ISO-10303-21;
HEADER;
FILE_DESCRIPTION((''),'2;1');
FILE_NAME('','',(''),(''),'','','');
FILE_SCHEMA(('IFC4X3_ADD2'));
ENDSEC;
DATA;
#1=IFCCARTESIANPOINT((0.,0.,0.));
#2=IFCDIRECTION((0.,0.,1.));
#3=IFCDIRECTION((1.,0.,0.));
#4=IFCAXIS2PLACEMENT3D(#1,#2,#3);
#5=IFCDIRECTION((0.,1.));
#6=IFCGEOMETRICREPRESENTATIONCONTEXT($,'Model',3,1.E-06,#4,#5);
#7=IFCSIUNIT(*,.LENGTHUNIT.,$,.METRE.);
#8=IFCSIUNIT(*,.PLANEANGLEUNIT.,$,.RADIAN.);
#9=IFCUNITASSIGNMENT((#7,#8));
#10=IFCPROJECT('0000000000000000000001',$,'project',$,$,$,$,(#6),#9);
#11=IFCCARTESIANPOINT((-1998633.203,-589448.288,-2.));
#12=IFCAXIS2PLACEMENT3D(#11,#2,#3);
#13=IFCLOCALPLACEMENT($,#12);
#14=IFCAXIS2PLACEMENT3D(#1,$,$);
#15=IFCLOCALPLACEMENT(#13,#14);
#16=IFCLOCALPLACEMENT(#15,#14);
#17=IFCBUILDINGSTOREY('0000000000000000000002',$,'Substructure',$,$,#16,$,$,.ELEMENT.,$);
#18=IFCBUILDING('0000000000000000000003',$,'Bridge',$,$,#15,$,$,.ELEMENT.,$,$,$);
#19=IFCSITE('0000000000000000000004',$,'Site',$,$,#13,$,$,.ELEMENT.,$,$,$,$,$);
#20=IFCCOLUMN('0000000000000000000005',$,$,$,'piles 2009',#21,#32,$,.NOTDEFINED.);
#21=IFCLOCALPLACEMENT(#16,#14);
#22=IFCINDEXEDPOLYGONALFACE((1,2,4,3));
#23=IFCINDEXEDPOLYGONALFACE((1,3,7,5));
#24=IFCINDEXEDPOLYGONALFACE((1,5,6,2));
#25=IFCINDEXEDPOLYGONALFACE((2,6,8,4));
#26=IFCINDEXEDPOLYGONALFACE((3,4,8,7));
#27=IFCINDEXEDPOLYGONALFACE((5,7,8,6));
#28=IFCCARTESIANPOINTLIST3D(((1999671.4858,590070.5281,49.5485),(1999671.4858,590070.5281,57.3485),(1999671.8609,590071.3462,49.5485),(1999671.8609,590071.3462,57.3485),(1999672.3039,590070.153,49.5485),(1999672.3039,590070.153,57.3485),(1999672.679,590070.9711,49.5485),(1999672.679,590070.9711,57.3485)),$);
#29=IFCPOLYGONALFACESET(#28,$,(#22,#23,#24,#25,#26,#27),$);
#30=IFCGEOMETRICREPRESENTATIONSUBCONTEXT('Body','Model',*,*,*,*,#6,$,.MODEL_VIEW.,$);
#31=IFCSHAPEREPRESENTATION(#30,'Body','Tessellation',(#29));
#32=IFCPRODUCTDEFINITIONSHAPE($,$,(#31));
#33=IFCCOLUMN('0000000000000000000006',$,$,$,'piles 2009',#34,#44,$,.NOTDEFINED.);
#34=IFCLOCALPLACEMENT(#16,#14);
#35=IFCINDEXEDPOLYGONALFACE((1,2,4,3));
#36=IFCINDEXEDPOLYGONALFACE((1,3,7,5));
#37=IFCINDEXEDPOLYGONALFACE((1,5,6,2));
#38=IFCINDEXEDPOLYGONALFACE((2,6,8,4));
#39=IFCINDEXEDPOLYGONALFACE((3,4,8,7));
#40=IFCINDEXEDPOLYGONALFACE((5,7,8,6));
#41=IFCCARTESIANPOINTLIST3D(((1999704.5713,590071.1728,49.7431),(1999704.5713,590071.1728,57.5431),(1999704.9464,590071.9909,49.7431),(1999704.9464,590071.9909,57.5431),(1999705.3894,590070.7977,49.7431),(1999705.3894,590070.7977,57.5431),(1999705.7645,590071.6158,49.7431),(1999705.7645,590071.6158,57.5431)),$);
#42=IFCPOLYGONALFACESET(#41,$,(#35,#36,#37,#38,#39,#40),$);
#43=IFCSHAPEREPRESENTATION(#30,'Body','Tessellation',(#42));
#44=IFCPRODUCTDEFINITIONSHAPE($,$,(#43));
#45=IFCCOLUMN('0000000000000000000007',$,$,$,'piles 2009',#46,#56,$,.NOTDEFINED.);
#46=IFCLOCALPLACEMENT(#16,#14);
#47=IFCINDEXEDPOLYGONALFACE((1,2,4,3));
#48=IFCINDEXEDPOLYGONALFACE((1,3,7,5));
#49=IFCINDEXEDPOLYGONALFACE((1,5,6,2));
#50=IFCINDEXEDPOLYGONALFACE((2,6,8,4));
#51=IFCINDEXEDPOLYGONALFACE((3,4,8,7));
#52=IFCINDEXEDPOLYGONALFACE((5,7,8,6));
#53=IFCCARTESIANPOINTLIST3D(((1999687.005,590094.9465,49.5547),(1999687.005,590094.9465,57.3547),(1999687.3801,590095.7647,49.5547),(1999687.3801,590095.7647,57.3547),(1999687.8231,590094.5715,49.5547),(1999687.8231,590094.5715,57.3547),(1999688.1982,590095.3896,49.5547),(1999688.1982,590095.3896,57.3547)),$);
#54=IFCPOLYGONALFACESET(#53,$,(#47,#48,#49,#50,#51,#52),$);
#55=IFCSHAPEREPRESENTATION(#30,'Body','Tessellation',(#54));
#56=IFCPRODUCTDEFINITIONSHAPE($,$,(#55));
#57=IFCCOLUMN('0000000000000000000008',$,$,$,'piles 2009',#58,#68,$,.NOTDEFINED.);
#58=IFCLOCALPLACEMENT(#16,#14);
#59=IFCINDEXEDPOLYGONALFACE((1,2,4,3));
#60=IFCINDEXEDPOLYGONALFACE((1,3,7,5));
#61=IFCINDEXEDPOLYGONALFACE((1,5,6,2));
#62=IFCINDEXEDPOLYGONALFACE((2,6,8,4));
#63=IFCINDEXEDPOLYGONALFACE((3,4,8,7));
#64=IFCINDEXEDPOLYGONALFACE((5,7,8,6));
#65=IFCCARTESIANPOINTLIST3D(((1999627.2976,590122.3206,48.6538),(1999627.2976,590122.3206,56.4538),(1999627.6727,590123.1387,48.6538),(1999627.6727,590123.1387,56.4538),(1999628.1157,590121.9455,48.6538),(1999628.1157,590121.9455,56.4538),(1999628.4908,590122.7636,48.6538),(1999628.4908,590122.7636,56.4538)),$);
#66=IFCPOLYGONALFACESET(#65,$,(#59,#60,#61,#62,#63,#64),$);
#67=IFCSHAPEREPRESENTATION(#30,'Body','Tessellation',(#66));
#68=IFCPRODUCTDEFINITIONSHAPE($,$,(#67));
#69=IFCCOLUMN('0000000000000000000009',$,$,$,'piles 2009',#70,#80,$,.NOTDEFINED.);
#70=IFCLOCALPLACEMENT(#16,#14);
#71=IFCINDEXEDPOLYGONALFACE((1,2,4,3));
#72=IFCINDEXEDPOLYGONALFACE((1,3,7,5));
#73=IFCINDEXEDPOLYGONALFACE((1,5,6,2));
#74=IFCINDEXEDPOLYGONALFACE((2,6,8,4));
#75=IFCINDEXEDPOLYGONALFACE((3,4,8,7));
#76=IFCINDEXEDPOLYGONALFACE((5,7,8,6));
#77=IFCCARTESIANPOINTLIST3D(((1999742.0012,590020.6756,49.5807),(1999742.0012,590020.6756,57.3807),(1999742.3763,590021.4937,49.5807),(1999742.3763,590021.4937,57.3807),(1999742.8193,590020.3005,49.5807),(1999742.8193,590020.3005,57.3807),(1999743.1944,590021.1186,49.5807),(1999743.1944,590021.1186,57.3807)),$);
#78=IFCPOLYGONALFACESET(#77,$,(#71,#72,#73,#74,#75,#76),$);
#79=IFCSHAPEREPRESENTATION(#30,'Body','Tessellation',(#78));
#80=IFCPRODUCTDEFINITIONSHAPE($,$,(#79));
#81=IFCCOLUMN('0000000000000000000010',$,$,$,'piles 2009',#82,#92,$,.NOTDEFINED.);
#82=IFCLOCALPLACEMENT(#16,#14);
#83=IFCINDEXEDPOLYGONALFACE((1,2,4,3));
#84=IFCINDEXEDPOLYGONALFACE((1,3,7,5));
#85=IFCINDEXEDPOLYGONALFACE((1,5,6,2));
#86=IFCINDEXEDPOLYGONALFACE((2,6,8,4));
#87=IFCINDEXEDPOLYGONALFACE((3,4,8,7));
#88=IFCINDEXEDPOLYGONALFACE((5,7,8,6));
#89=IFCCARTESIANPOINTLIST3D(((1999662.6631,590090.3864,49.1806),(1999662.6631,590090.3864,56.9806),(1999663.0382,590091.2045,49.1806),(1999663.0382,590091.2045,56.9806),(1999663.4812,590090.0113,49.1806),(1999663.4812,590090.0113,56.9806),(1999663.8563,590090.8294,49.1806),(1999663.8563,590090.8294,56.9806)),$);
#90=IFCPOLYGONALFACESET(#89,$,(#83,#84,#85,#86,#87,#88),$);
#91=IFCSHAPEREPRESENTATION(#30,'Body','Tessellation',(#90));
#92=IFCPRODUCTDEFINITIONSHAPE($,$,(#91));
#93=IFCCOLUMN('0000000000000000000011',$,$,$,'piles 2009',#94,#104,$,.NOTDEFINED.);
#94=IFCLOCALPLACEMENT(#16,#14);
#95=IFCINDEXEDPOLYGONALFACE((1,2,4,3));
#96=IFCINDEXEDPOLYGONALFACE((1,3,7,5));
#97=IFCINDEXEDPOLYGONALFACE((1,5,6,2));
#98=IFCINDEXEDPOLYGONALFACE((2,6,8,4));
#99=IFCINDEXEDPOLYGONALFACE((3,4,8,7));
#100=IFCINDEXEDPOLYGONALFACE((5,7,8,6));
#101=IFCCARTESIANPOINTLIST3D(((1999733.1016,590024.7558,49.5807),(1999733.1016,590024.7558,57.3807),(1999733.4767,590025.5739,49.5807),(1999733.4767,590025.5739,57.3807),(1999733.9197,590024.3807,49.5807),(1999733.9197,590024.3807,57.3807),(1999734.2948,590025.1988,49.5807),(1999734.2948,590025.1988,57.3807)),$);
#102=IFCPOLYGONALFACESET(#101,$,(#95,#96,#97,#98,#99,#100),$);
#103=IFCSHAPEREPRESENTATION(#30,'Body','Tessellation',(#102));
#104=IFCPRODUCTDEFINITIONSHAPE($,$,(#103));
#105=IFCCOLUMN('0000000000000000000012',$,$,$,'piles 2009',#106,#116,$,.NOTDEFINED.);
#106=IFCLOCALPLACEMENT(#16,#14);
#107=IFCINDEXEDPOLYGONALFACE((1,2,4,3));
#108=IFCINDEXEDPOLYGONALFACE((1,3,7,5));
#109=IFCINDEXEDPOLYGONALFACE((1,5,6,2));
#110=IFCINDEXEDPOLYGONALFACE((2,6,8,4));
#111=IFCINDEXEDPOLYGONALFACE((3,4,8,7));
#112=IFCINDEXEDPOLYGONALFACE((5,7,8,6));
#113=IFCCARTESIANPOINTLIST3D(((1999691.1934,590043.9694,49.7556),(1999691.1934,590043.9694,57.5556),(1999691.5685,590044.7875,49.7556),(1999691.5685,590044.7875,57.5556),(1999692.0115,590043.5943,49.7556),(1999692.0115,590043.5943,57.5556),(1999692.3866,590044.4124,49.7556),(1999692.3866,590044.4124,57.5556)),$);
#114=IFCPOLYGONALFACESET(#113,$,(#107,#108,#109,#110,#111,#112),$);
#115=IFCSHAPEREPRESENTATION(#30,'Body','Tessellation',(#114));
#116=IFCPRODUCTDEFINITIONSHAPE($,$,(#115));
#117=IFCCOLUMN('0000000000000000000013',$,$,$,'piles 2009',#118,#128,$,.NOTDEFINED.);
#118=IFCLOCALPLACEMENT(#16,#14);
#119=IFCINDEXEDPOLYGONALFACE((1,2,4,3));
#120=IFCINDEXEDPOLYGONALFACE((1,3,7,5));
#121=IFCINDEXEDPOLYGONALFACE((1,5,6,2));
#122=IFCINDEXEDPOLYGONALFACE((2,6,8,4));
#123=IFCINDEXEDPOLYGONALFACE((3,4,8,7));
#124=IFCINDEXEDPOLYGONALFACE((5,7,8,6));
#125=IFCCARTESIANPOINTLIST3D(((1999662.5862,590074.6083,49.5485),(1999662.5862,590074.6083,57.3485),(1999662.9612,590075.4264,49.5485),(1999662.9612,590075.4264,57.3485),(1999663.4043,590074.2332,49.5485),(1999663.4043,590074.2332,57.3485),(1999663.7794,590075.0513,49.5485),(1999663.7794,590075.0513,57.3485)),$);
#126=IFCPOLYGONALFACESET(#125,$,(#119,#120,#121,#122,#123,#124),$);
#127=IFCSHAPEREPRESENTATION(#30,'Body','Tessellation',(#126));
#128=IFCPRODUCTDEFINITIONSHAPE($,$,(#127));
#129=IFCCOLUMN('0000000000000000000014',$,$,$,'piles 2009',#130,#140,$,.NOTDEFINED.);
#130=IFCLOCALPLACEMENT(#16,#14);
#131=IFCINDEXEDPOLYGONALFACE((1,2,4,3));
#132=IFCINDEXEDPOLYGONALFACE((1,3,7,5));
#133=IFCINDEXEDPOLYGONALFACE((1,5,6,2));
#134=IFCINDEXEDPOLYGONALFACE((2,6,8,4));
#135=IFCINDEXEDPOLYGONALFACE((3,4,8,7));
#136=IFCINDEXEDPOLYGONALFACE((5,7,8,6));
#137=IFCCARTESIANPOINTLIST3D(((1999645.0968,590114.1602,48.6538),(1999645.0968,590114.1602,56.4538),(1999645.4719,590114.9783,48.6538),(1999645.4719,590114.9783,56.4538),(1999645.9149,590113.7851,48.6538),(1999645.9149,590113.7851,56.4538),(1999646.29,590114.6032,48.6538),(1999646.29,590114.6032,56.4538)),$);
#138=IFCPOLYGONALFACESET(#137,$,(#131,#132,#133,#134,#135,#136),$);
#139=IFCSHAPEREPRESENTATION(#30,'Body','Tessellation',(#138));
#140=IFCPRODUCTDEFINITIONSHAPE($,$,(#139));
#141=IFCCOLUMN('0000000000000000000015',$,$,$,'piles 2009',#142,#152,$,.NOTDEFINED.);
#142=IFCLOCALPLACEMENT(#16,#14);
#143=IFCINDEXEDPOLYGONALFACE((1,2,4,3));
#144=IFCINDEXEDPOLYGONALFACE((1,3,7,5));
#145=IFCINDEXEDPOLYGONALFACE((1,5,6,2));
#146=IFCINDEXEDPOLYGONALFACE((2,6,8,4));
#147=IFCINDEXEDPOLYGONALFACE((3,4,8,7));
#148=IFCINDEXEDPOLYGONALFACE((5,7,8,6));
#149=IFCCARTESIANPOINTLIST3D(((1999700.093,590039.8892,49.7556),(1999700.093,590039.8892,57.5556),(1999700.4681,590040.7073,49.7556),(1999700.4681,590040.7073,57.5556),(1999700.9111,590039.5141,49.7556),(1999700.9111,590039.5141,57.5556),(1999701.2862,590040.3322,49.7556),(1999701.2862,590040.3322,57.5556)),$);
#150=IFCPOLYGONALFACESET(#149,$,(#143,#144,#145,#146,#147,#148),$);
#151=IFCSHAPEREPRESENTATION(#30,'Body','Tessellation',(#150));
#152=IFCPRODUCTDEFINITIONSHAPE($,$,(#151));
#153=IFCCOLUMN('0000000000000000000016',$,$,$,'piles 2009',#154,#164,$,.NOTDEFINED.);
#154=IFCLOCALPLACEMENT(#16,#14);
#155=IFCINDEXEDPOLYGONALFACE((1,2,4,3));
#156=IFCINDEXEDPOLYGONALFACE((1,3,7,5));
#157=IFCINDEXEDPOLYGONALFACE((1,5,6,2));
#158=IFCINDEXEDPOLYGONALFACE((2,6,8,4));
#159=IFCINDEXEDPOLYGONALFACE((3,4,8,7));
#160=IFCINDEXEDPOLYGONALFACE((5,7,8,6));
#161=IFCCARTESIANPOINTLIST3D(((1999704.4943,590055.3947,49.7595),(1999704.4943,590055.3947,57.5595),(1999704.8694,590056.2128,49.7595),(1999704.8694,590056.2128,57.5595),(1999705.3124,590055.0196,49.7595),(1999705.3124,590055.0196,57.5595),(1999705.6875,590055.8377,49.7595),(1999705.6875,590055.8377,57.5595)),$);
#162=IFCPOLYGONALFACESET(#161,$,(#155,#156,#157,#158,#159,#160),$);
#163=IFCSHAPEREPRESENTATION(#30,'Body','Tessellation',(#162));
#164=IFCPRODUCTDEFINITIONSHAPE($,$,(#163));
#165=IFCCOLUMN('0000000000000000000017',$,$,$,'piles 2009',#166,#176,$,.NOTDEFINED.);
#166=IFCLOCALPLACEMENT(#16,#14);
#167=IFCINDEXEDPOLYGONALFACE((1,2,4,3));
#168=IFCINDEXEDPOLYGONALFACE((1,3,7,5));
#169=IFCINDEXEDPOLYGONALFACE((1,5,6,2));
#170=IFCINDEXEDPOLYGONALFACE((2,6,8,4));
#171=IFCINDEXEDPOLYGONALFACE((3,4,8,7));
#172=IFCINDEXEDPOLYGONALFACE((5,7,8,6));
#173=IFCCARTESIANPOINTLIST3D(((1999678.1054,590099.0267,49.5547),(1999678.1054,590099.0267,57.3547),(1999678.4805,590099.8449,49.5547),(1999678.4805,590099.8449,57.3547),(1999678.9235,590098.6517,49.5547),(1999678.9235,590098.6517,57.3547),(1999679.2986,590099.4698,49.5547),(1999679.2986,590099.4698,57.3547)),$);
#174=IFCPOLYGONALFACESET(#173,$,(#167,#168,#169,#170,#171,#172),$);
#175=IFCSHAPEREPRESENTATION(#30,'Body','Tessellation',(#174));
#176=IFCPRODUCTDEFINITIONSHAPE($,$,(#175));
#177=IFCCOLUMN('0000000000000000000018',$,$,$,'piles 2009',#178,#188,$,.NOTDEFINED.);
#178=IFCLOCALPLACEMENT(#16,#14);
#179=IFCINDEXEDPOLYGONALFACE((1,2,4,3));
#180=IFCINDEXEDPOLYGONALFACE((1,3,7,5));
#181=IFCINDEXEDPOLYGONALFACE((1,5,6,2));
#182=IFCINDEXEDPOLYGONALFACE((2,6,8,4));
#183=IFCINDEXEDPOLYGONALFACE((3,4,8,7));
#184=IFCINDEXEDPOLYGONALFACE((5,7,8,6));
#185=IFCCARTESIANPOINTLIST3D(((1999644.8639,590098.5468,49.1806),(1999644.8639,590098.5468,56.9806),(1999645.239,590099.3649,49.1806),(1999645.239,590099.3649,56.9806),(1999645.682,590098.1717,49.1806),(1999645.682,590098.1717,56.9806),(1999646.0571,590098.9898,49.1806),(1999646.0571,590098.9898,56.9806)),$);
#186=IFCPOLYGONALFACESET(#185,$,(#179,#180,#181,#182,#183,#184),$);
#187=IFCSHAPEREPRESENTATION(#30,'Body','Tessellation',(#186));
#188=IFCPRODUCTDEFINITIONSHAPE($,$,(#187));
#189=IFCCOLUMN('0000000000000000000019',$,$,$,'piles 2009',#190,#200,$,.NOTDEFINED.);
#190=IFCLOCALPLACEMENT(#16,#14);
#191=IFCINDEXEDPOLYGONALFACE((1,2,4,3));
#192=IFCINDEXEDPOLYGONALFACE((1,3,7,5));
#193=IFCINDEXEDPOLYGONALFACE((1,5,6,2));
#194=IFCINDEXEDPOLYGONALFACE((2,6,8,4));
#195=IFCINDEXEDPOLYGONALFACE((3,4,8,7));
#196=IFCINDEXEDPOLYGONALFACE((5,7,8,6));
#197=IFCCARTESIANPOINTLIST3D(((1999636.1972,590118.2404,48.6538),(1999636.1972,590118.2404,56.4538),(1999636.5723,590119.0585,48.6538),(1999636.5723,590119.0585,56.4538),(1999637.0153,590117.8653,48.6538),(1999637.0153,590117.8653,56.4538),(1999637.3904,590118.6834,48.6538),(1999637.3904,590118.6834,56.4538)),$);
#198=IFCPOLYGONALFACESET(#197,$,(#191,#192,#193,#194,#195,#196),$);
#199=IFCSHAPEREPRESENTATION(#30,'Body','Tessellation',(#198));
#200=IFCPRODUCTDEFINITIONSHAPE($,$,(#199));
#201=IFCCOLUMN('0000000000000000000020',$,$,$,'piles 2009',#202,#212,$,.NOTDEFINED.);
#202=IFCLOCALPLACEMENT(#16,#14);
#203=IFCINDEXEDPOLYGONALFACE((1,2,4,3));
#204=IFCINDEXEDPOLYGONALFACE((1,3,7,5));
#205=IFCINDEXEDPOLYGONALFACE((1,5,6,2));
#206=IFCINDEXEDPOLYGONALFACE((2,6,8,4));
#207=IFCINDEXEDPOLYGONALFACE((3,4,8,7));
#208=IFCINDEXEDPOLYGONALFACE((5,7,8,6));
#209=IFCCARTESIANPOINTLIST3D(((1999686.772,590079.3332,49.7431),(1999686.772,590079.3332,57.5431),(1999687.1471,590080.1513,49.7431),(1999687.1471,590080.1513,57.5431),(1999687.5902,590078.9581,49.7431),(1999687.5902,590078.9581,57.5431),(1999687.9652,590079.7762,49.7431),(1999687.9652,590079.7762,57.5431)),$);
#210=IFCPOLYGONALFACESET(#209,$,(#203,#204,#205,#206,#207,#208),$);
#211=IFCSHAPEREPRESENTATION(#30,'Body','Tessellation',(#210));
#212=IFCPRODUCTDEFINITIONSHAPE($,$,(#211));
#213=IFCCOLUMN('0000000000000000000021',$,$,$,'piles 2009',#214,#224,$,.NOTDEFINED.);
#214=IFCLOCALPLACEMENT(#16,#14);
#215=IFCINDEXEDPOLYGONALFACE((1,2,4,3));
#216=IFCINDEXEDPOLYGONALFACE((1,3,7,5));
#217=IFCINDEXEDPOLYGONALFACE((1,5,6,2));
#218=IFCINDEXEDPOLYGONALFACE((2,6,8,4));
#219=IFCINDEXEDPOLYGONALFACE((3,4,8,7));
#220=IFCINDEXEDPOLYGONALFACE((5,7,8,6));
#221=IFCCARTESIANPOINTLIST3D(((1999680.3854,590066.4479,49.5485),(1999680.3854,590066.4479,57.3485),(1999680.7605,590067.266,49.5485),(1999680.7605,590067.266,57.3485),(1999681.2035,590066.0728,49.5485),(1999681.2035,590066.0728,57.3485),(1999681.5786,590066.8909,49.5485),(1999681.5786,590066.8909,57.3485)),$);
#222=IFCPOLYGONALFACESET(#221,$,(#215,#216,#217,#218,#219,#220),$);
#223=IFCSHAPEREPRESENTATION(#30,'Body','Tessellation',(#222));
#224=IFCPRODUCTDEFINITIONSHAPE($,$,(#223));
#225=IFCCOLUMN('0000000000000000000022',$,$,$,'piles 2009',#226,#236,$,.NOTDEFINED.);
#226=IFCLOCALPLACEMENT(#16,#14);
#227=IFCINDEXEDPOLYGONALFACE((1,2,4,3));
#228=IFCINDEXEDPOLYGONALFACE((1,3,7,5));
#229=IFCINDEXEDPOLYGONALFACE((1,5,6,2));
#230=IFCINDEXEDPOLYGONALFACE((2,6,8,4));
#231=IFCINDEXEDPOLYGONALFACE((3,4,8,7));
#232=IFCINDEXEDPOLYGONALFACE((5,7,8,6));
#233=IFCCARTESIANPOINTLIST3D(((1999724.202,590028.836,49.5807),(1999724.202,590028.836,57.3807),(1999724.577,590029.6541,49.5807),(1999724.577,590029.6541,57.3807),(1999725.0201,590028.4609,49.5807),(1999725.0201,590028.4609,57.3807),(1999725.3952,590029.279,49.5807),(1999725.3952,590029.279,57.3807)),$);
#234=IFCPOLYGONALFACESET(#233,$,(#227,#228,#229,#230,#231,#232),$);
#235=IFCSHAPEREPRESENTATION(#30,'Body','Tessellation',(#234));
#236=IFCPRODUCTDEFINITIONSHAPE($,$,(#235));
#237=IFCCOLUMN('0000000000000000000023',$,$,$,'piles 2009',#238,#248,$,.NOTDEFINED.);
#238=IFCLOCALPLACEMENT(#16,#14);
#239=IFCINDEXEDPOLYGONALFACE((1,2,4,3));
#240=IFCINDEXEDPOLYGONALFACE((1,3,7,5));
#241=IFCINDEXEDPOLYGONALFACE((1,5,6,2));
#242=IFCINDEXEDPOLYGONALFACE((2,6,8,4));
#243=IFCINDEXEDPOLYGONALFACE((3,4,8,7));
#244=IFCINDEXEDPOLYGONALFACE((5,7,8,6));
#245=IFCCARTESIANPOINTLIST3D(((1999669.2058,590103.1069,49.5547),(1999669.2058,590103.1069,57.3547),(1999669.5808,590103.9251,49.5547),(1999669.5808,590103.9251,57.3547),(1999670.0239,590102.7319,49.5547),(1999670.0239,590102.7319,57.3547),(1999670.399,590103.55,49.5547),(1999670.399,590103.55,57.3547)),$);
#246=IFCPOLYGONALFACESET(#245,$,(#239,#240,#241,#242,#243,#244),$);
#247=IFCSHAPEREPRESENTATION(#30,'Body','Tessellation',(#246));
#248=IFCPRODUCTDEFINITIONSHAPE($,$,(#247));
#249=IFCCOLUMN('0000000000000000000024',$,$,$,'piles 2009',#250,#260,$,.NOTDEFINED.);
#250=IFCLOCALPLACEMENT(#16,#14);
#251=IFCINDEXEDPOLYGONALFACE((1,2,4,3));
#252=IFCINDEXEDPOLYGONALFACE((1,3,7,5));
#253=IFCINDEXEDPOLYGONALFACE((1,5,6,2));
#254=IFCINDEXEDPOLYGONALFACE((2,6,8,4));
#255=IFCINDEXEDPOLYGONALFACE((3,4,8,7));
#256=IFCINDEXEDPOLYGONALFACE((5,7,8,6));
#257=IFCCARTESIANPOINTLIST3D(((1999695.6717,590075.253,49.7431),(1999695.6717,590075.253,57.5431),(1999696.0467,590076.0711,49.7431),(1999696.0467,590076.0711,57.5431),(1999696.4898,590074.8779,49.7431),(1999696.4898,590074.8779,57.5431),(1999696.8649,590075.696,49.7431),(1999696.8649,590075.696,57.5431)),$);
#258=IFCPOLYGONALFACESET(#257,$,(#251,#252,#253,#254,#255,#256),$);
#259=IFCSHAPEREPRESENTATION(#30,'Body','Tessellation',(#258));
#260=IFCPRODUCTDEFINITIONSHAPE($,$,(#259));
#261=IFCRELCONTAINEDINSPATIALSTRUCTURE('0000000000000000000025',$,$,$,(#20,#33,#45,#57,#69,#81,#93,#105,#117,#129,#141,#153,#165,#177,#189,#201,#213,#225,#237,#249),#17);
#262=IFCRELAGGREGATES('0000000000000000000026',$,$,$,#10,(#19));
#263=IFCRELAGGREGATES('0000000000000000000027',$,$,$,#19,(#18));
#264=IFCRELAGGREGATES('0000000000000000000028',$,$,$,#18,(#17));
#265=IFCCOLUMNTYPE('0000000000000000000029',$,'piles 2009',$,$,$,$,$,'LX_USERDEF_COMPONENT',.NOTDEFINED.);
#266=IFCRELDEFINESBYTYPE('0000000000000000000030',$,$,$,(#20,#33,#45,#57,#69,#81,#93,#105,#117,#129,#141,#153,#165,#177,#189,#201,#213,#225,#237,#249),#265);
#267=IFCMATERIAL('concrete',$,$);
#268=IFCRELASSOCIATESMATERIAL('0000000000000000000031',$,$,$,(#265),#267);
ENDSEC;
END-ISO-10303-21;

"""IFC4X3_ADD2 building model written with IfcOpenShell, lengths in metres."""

from ifc_helpers import new_model, si_unit, direction, frame, frame_2d, origin, origin_with_axes, place, context, subcontext, project, spatial, rectangle, extrude, material, type_object, element, save


model = new_model("IFC4X3_ADD2")

# Units and contexts
model_context = context("Model", 3, precision=1e-06, world=origin_with_axes(), true_north=direction((0.0, 1.0)))
body_context = subcontext(model_context, "Body", "Model", "MODEL_VIEW")
ifc_project = project(units=[si_unit("LENGTHUNIT", "METRE"), si_unit("PLANEANGLEUNIT", "RADIAN")], contexts=[model_context])

# Site, building, storey
site_placement = place(None, frame((-1998633.203, -589448.288, -2.0), z_axis=(0.0, 0.0, 1.0), x_axis=(1.0, 0.0, 0.0)))
site = spatial("IfcSite", under=ifc_project, at=site_placement, Name="Site", CompositionType="ELEMENT")
building_placement = place(site_placement, origin())
building = spatial("IfcBuilding", under=site, at=building_placement, Name="Bridge", CompositionType="ELEMENT")
storey_placement = place(building_placement, origin())
storey = spatial("IfcBuildingStorey", under=building, at=storey_placement, Name="Substructure", CompositionType="ELEMENT")

# Columns
ifc_material = material(Name="concrete")
column_type = type_object("IfcColumnType", Name="piles 2009", ElementType="LX_USERDEF_COMPONENT", PredefinedType="NOTDEFINED", material=ifc_material)
for number, where, z_axis, x_axis in (
    (1, (1999672.3039, 590070.153, 49.5485), (0.0, 0.0, 1.0), (0.416757, 0.909018, 0.0)),
    (2, (1999705.3894, 590070.7977, 49.7431), (0.0, 0.0, 1.0), (0.416757, 0.909018, 0.0)),
    (3, (1999687.8231, 590094.5715, 49.5547), (0.0, 0.0, 1.0), (0.416757, 0.909018, 0.0)),
    (4, (1999628.1157, 590121.9455, 48.6538), (0.0, 0.0, 1.0), (0.416757, 0.909018, 0.0)),
    (5, (1999742.8193, 590020.3005, 49.5807), (0.0, 0.0, 1.0), (0.416757, 0.909018, 0.0)),
    (6, (1999663.4812, 590090.0113, 49.1806), (0.0, 0.0, 1.0), (0.416757, 0.909018, 0.0)),
    (7, (1999733.9197, 590024.3807, 49.5807), (0.0, 0.0, 1.0), (0.416757, 0.909018, 0.0)),
    (8, (1999692.0115, 590043.5943, 49.7556), (0.0, 0.0, 1.0), (0.416757, 0.909018, 0.0)),
    (9, (1999663.4043, 590074.2332, 49.5485), (0.0, 0.0, 1.0), (0.416757, 0.909018, 0.0)),
    (10, (1999645.9149, 590113.7851, 48.6538), (0.0, 0.0, 1.0), (0.416757, 0.909018, 0.0)),
    (11, (1999700.9111, 590039.5141, 49.7556), (0.0, 0.0, 1.0), (0.416757, 0.909018, 0.0)),
    (12, (1999705.3124, 590055.0196, 49.7595), (0.0, 0.0, 1.0), (0.416757, 0.909018, 0.0)),
    (13, (1999678.9235, 590098.6517, 49.5547), (0.0, 0.0, 1.0), (0.416757, 0.909018, 0.0)),
    (14, (1999645.682, 590098.1717, 49.1806), (0.0, 0.0, 1.0), (0.416757, 0.909018, 0.0)),
    (15, (1999637.0153, 590117.8653, 48.6538), (0.0, 0.0, 1.0), (0.416757, 0.909018, 0.0)),
    (16, (1999687.5902, 590078.9581, 49.7431), (0.0, 0.0, 1.0), (0.416757, 0.909018, 0.0)),
    (17, (1999681.2035, 590066.0728, 49.5485), (0.0, 0.0, 1.0), (0.416757, 0.909018, 0.0)),
    (18, (1999725.0201, 590028.4609, 49.5807), (0.0, 0.0, 1.0), (0.416757, 0.909018, 0.0)),
    (19, (1999670.0239, 590102.7319, 49.5547), (0.0, 0.0, 1.0), (0.416757, 0.909018, 0.0)),
    (20, (1999696.4898, 590074.8779, 49.7431), (0.0, 0.0, 1.0), (0.416757, 0.909018, 0.0)),
):
    element("IfcColumn", number, at=place(storey_placement, frame(where, z_axis=z_axis, x_axis=x_axis)), inside=storey, type_object=column_type, ObjectType="piles 2009", PredefinedType="NOTDEFINED", context=body_context, shape_type="SweptSolid", body=[
        extrude(rectangle(XDim=0.9, YDim=0.9, at=frame_2d((0.45, 0.45), x_axis=(1.0, 0.0))), origin_with_axes(), (0.0, 0.0, 1.0), 7.8),
    ])

save(model, "model.ifc")
